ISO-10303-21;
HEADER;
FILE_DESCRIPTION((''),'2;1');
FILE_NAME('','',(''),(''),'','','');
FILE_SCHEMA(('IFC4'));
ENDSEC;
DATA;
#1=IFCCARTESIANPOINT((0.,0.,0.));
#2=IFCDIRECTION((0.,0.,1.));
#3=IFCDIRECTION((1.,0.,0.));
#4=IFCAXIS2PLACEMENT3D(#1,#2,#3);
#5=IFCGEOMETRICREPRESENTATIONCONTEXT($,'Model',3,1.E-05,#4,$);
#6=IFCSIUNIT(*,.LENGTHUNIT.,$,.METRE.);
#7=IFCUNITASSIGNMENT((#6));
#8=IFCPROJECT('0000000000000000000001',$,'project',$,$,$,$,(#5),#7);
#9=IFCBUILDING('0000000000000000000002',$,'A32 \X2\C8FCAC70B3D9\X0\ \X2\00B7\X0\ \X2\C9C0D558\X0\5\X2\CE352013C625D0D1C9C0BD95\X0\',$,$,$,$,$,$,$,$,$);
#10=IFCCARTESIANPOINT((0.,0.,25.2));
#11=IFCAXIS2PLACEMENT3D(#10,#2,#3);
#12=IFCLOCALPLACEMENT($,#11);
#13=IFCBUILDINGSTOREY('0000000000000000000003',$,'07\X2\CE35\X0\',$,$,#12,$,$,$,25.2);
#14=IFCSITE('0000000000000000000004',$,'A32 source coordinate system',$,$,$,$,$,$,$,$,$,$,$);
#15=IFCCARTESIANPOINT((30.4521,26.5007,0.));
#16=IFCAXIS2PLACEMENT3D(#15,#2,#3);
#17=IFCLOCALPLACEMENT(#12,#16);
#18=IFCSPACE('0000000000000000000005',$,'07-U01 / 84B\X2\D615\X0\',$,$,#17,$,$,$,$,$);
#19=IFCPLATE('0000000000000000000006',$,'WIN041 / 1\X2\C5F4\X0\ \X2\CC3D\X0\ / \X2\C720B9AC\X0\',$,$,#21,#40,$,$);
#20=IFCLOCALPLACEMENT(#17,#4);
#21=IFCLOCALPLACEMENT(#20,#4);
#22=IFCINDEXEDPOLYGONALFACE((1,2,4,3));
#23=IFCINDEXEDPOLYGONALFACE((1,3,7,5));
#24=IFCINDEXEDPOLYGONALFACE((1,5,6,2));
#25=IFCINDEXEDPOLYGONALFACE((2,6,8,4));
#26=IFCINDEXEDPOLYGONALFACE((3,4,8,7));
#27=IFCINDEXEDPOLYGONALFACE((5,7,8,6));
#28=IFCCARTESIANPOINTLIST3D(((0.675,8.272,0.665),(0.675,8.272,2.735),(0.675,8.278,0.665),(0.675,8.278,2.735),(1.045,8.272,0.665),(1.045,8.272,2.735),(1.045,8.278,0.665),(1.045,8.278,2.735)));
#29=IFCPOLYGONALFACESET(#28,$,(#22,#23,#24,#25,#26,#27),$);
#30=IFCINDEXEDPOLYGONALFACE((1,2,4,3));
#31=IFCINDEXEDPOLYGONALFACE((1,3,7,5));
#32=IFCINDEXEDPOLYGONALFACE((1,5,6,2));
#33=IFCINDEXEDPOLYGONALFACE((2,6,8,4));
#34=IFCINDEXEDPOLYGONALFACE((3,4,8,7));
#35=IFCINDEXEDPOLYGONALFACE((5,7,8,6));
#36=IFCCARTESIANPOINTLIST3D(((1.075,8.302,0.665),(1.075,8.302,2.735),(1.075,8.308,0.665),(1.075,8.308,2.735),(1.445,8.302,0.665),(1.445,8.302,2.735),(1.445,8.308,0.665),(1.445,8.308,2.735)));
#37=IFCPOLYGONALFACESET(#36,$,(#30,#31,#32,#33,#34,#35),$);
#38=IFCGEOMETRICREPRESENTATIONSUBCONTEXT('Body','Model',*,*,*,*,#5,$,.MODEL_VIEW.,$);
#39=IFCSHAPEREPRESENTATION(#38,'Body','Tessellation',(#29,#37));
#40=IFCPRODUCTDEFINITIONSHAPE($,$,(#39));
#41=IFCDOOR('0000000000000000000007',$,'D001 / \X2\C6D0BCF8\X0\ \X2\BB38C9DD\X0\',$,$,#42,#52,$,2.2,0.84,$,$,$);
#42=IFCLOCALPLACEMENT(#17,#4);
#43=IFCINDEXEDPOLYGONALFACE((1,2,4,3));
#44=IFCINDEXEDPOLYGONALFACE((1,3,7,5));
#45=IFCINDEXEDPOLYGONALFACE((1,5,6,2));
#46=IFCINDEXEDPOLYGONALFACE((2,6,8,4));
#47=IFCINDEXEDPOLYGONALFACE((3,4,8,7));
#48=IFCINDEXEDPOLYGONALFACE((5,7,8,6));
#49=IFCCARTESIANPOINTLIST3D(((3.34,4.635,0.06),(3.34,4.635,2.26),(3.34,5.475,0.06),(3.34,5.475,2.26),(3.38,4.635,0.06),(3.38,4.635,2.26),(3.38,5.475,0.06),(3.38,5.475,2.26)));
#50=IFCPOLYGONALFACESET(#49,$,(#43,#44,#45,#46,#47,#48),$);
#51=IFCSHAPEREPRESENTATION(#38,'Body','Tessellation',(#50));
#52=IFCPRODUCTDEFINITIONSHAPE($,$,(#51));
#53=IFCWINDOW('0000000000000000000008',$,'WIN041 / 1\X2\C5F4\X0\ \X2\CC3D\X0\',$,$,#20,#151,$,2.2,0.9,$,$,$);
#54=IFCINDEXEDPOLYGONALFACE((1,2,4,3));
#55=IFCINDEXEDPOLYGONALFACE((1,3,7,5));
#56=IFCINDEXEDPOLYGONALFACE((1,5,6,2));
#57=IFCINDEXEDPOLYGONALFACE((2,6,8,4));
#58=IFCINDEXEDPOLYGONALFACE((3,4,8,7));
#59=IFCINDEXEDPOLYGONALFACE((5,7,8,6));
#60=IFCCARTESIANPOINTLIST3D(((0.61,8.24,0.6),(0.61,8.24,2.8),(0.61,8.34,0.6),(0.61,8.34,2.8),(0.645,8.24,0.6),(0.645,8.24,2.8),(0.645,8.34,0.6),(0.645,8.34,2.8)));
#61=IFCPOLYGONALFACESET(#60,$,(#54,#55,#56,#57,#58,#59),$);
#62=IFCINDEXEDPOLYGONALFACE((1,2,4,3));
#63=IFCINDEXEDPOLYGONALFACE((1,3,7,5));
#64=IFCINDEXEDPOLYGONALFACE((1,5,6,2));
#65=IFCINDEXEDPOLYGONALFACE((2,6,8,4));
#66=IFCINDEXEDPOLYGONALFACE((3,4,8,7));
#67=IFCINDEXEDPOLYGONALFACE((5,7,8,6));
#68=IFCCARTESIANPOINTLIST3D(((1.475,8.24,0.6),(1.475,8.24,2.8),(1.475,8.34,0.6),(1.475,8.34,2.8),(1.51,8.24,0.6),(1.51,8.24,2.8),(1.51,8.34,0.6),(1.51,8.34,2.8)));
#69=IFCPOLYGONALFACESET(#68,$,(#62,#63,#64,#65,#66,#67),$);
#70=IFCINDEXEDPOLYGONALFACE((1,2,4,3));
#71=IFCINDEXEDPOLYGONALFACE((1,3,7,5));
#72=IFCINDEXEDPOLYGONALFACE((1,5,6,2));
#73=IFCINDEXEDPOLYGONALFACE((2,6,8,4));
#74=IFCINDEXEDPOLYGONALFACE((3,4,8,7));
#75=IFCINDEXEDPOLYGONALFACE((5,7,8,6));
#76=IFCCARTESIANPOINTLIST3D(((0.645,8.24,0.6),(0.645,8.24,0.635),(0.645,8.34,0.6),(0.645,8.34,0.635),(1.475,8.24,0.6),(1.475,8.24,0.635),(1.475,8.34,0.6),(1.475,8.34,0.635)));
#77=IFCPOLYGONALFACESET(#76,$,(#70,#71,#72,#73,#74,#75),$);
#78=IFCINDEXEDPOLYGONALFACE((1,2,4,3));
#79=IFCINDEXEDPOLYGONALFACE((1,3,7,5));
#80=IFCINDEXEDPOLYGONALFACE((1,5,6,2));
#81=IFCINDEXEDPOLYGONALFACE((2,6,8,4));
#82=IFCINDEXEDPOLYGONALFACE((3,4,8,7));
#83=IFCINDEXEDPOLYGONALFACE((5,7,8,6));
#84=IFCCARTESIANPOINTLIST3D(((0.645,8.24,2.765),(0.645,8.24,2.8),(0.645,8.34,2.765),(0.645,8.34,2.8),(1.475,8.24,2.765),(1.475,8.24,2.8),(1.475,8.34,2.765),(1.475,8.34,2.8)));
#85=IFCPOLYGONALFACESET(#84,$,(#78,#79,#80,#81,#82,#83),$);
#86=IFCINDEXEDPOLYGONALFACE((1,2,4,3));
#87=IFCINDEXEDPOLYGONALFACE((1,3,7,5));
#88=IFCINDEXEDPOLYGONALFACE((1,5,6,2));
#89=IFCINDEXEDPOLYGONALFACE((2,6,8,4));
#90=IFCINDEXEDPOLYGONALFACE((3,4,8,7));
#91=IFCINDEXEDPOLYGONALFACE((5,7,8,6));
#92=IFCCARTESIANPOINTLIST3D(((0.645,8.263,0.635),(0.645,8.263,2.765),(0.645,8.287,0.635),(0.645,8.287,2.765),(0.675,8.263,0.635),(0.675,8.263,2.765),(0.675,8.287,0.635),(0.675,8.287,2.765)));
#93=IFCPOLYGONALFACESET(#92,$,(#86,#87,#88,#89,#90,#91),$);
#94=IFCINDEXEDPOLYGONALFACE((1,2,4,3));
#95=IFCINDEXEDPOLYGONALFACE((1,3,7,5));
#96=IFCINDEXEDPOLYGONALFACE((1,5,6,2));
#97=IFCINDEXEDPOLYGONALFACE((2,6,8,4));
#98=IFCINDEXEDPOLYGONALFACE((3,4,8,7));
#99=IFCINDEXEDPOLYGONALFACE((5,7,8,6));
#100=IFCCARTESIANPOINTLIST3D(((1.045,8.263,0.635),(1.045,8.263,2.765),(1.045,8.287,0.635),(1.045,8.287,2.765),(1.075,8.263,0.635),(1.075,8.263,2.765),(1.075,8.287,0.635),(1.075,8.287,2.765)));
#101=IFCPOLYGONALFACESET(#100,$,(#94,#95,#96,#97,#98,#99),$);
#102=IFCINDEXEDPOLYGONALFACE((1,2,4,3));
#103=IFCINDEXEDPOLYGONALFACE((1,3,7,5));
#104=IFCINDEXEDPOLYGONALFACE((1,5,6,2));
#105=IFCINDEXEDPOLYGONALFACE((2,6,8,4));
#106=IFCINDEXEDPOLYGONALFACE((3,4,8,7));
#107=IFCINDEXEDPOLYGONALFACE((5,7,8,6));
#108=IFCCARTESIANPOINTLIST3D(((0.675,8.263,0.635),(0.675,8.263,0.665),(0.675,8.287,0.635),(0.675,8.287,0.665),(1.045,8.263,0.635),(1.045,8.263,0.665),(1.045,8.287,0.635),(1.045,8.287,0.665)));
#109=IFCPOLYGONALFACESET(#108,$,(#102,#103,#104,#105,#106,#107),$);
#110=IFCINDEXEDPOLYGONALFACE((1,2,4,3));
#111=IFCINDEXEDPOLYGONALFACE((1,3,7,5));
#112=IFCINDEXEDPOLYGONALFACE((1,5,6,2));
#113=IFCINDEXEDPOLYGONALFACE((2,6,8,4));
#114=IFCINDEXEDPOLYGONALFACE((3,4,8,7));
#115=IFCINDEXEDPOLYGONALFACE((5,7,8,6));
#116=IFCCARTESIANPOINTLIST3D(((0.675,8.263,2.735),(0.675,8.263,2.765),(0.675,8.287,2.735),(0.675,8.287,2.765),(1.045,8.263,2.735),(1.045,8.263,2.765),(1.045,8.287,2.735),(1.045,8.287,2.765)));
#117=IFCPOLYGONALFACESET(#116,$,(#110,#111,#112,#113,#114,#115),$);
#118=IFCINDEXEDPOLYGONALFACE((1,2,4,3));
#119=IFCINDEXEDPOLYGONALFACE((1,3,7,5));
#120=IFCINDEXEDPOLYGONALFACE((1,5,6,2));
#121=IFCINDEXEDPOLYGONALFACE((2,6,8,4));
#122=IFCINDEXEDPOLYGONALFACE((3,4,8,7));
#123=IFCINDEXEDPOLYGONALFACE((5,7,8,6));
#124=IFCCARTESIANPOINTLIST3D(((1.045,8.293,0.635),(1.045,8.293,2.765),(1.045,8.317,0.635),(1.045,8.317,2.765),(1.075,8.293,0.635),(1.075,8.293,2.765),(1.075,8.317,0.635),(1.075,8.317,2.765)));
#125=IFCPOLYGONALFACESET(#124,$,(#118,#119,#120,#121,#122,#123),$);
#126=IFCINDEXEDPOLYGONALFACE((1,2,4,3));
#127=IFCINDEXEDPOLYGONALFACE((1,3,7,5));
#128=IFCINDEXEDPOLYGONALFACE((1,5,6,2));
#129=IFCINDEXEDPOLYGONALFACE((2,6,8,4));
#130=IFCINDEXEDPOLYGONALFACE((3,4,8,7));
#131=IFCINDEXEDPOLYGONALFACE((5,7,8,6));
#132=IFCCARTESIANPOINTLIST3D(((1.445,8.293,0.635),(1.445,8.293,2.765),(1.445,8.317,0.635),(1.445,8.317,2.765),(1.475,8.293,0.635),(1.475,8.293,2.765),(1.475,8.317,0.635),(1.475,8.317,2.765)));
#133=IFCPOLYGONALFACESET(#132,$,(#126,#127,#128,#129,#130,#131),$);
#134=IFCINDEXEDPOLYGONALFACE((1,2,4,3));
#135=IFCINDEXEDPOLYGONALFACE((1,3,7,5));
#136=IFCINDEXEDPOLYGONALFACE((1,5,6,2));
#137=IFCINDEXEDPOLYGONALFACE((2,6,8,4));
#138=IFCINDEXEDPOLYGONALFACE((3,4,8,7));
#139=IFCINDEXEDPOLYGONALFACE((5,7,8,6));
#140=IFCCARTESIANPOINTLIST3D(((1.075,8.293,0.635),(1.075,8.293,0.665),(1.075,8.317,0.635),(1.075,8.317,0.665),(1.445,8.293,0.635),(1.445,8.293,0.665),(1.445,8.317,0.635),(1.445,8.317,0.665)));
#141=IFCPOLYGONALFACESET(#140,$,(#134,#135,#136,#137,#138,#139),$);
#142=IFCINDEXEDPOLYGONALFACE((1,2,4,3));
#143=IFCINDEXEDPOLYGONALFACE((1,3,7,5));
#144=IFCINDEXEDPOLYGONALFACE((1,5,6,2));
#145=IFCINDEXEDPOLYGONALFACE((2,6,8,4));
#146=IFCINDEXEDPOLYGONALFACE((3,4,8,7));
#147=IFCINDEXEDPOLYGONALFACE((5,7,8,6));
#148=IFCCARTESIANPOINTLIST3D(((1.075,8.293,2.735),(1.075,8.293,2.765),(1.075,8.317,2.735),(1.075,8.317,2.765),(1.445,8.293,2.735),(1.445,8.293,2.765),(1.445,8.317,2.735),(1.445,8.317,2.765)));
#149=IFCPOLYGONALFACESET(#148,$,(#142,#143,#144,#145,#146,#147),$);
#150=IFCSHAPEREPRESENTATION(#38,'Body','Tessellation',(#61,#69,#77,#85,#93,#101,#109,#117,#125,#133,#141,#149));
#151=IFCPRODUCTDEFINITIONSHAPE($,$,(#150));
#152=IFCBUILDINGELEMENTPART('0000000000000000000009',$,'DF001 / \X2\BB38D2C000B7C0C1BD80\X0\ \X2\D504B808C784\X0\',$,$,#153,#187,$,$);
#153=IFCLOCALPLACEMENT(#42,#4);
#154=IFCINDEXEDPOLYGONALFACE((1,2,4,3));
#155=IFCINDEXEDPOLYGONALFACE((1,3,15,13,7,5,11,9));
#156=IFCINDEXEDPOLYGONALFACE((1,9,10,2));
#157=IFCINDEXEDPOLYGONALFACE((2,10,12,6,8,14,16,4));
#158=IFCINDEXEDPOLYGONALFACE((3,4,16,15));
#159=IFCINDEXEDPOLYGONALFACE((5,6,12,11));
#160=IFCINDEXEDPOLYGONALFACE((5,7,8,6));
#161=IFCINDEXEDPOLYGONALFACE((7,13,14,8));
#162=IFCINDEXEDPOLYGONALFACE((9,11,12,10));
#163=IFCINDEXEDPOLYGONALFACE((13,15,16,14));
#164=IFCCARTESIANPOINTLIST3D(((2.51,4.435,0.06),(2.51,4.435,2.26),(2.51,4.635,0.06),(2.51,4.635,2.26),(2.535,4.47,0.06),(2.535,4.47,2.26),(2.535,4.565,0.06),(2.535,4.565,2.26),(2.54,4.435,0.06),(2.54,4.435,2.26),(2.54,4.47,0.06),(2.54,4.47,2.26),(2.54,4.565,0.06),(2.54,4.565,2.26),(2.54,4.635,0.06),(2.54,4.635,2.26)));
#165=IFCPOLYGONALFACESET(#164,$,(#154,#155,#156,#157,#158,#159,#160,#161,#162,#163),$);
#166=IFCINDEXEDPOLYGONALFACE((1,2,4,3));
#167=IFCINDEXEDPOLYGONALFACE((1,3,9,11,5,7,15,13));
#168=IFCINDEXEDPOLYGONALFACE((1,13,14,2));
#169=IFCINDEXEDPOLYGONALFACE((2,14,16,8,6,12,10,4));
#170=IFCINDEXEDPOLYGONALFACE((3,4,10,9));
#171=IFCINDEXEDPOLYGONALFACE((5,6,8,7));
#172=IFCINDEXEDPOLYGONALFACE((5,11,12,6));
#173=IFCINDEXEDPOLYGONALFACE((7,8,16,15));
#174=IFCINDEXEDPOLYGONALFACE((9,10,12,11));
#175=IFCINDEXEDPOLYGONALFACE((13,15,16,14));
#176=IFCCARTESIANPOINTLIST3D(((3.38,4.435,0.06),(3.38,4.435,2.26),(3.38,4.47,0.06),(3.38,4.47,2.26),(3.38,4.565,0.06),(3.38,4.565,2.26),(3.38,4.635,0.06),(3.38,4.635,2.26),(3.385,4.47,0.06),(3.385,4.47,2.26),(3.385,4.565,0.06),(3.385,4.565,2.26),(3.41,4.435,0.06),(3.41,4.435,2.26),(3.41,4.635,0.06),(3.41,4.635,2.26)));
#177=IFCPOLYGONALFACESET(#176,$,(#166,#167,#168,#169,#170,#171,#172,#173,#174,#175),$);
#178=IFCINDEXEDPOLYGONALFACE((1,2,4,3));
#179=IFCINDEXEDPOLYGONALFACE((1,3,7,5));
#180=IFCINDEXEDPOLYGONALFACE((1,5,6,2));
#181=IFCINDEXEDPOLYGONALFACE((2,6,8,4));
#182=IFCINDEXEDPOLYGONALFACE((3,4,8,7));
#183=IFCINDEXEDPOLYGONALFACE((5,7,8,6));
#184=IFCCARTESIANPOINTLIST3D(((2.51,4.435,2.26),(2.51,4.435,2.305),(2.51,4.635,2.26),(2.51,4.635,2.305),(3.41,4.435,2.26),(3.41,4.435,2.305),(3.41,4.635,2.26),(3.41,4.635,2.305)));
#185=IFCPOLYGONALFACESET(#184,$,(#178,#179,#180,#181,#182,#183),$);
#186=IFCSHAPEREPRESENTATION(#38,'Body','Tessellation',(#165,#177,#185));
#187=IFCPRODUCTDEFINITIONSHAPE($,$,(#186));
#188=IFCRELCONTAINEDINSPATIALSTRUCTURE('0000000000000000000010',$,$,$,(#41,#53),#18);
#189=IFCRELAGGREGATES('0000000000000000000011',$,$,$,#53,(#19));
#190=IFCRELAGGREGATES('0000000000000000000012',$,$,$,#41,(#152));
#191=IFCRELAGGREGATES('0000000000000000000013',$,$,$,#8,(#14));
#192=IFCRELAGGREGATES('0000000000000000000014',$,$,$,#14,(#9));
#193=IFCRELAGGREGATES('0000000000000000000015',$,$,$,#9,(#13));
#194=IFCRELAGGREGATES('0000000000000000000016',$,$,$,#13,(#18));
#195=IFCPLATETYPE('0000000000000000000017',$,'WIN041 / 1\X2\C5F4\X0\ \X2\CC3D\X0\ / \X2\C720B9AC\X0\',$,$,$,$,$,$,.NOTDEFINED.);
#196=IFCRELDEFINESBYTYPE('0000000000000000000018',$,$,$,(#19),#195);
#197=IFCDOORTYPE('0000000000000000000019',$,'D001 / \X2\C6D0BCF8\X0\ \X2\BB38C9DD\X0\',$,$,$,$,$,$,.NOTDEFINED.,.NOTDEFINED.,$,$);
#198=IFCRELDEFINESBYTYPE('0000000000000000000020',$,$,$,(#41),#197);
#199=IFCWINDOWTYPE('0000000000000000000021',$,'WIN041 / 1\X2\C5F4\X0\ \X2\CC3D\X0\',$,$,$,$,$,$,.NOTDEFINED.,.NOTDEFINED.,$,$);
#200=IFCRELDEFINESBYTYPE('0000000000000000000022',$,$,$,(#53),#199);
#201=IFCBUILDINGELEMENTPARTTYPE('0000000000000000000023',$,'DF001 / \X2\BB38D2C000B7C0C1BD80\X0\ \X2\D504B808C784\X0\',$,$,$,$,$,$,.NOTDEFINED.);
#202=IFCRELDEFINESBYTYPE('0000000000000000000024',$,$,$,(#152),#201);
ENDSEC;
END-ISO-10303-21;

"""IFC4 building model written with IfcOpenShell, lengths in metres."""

from ifc_helpers import new_model, si_unit, frame, origin, origin_with_axes, place, context, subcontext, project, spatial, polyline, outline, extrude, source, transform, mapped, type_object, type_shapes, element, aggregate, save


model = new_model("IFC4")

# Units and contexts
model_context = context("Model", 3, precision=1e-05, world=origin_with_axes())
body_context = subcontext(model_context, "Body", "Model", "MODEL_VIEW")
ifc_project = project(units=[si_unit("LENGTHUNIT", "METRE")], contexts=[model_context])

# Plate
storey_placement = place(None, frame((0.0, 0.0, 25.2), z_axis=(0.0, 0.0, 1.0), x_axis=(1.0, 0.0, 0.0)))
space_placement = place(storey_placement, frame((30.4521, 26.5007, 0.0), z_axis=(0.0, 0.0, 1.0), x_axis=(1.0, 0.0, 0.0)))
plate_type_1 = type_object("IfcPlateType", Name="WIN041 / 1열 창 / 유리", PredefinedType="NOTDEFINED")
shared_shape_1 = source(origin(), body_context, "Body", "SweptSolid", [
    extrude(outline(polyline([(0.675, 8.272), (0.675, 8.278), (1.045, 8.278), (1.045, 8.272), (0.675, 8.272)])), frame((0.0, 0.0, 0.665)), (0.0, 0.0, 1.0), 2.07),
    extrude(outline(polyline([(1.075, 8.302), (1.075, 8.308), (1.445, 8.308), (1.445, 8.302), (1.075, 8.302)])), frame((0.0, 0.0, 0.665)), (0.0, 0.0, 1.0), 2.07),
])
type_shapes(plate_type_1, [shared_shape_1])
window_1_placement = place(space_placement, origin_with_axes())
plate_1_placement = place(window_1_placement, origin_with_axes())
plate_1 = element("IfcPlate", 1, at=plate_1_placement, type_object=plate_type_1, Name="WIN041 / 1열 창 / 유리", context=body_context, shape_type="MappedRepresentation", body=[
    mapped(shared_shape_1, transform((0.0, 0.0, 0.0), scale=1.0)),
])

# Site, building, storey, space
site = spatial("IfcSite", under=ifc_project, Name="A32 source coordinate system")
building = spatial("IfcBuilding", under=site, Name="A32 주거동 · 지하5층–옥탑지붕")
storey = spatial("IfcBuildingStorey", under=building, at=storey_placement, Name="07층", Elevation=25.2)
space = spatial("IfcSpace", under=storey, at=space_placement, Name="07-U01 / 84B형")

# Door
door_type_1 = type_object("IfcDoorType", Name="D001 / 원본 문짝", OperationType="NOTDEFINED", PredefinedType="NOTDEFINED")
shared_shape_2 = source(origin(), body_context, "Body", "SweptSolid", [
    extrude(outline(polyline([(3.34, 5.475), (3.38, 5.475), (3.38, 4.635), (3.34, 4.635), (3.34, 5.475)])), frame((0.0, 0.0, 0.06)), (0.0, 0.0, 1.0), 2.2),
])
type_shapes(door_type_1, [shared_shape_2])
door_1_placement = place(space_placement, origin_with_axes())
door_1 = element("IfcDoor", 2, at=door_1_placement, inside=space, type_object=door_type_1, Name="D001 / 원본 문짝", OverallHeight=2.2, OverallWidth=0.84, context=body_context, shape_type="MappedRepresentation", body=[
    mapped(shared_shape_2, transform((0.0, 0.0, 0.0), scale=1.0)),
])

# Window
window_type_1 = type_object("IfcWindowType", Name="WIN041 / 1열 창", PartitioningType="NOTDEFINED", PredefinedType="NOTDEFINED")
shared_shape_3 = source(origin(), body_context, "Body", "SweptSolid", [
    extrude(outline(polyline([(0.61, 8.24), (0.61, 8.34), (0.645, 8.34), (0.645, 8.24), (0.61, 8.24)])), frame((0.0, 0.0, 0.6)), (0.0, 0.0, 1.0), 2.2),
    extrude(outline(polyline([(1.475, 8.24), (1.475, 8.34), (1.51, 8.34), (1.51, 8.24), (1.475, 8.24)])), frame((0.0, 0.0, 0.6)), (0.0, 0.0, 1.0), 2.2),
    extrude(outline(polyline([(0.645, 8.24), (0.645, 8.34), (1.475, 8.34), (1.475, 8.24), (0.645, 8.24)])), frame((0.0, 0.0, 0.6)), (0.0, 0.0, 1.0), 0.035),
    extrude(outline(polyline([(0.645, 8.24), (0.645, 8.34), (1.475, 8.34), (1.475, 8.24), (0.645, 8.24)])), frame((0.0, 0.0, 2.765)), (0.0, 0.0, 1.0), 0.035),
    extrude(outline(polyline([(0.645, 8.263), (0.645, 8.287), (0.675, 8.287), (0.675, 8.263), (0.645, 8.263)])), frame((0.0, 0.0, 0.635)), (0.0, 0.0, 1.0), 2.13),
    extrude(outline(polyline([(1.045, 8.263), (1.045, 8.287), (1.075, 8.287), (1.075, 8.263), (1.045, 8.263)])), frame((0.0, 0.0, 0.635)), (0.0, 0.0, 1.0), 2.13),
    extrude(outline(polyline([(0.675, 8.263), (0.675, 8.287), (1.045, 8.287), (1.045, 8.263), (0.675, 8.263)])), frame((0.0, 0.0, 0.635)), (0.0, 0.0, 1.0), 0.03),
    extrude(outline(polyline([(0.675, 8.263), (0.675, 8.287), (1.045, 8.287), (1.045, 8.263), (0.675, 8.263)])), frame((0.0, 0.0, 2.735)), (0.0, 0.0, 1.0), 0.03),
    extrude(outline(polyline([(1.045, 8.293), (1.045, 8.317), (1.075, 8.317), (1.075, 8.293), (1.045, 8.293)])), frame((0.0, 0.0, 0.635)), (0.0, 0.0, 1.0), 2.13),
    extrude(outline(polyline([(1.445, 8.293), (1.445, 8.317), (1.475, 8.317), (1.475, 8.293), (1.445, 8.293)])), frame((0.0, 0.0, 0.635)), (0.0, 0.0, 1.0), 2.13),
    extrude(outline(polyline([(1.075, 8.293), (1.075, 8.317), (1.445, 8.317), (1.445, 8.293), (1.075, 8.293)])), frame((0.0, 0.0, 0.635)), (0.0, 0.0, 1.0), 0.03),
    extrude(outline(polyline([(1.075, 8.293), (1.075, 8.317), (1.445, 8.317), (1.445, 8.293), (1.075, 8.293)])), frame((0.0, 0.0, 2.735)), (0.0, 0.0, 1.0), 0.03),
])
type_shapes(window_type_1, [shared_shape_3])
window_1 = element("IfcWindow", 3, at=window_1_placement, inside=space, type_object=window_type_1, Name="WIN041 / 1열 창", OverallHeight=2.2, OverallWidth=0.9, context=body_context, shape_type="MappedRepresentation", body=[
    mapped(shared_shape_3, transform((0.0, 0.0, 0.0), scale=1.0)),
])
aggregate(window_1, [plate_1])

# Building element part
building_element_part_type_1 = type_object("IfcBuildingElementPartType", Name="DF001 / 문틀·상부 프레임", PredefinedType="NOTDEFINED")
shared_shape_4 = source(origin(), body_context, "Body", "SweptSolid", [
    extrude(outline(polyline([(2.54, 4.635), (2.54, 4.565), (2.535, 4.565), (2.535, 4.47), (2.54, 4.47), (2.54, 4.435), (2.51, 4.435), (2.51, 4.635), (2.54, 4.635)])), frame((0.0, 0.0, 0.06)), (0.0, 0.0, 1.0), 2.2),
    extrude(outline(polyline([(3.41, 4.435), (3.38, 4.435), (3.38, 4.47), (3.385, 4.47), (3.385, 4.565), (3.38, 4.565), (3.38, 4.635), (3.41, 4.635), (3.41, 4.435)])), frame((0.0, 0.0, 0.06)), (0.0, 0.0, 1.0), 2.2),
    extrude(outline(polyline([(2.51, 4.435), (2.51, 4.635), (3.41, 4.635), (3.41, 4.435), (2.51, 4.435)])), frame((0.0, 0.0, 2.26)), (0.0, 0.0, 1.0), 0.045),
])
type_shapes(building_element_part_type_1, [shared_shape_4])
building_element_part_1_placement = place(door_1_placement, origin_with_axes())
building_element_part_1 = element("IfcBuildingElementPart", 4, at=building_element_part_1_placement, type_object=building_element_part_type_1, Name="DF001 / 문틀·상부 프레임", context=body_context, shape_type="MappedRepresentation", body=[
    mapped(shared_shape_4, transform((0.0, 0.0, 0.0), scale=1.0)),
])
aggregate(door_1, [building_element_part_1])

save(model, "model.ifc")
